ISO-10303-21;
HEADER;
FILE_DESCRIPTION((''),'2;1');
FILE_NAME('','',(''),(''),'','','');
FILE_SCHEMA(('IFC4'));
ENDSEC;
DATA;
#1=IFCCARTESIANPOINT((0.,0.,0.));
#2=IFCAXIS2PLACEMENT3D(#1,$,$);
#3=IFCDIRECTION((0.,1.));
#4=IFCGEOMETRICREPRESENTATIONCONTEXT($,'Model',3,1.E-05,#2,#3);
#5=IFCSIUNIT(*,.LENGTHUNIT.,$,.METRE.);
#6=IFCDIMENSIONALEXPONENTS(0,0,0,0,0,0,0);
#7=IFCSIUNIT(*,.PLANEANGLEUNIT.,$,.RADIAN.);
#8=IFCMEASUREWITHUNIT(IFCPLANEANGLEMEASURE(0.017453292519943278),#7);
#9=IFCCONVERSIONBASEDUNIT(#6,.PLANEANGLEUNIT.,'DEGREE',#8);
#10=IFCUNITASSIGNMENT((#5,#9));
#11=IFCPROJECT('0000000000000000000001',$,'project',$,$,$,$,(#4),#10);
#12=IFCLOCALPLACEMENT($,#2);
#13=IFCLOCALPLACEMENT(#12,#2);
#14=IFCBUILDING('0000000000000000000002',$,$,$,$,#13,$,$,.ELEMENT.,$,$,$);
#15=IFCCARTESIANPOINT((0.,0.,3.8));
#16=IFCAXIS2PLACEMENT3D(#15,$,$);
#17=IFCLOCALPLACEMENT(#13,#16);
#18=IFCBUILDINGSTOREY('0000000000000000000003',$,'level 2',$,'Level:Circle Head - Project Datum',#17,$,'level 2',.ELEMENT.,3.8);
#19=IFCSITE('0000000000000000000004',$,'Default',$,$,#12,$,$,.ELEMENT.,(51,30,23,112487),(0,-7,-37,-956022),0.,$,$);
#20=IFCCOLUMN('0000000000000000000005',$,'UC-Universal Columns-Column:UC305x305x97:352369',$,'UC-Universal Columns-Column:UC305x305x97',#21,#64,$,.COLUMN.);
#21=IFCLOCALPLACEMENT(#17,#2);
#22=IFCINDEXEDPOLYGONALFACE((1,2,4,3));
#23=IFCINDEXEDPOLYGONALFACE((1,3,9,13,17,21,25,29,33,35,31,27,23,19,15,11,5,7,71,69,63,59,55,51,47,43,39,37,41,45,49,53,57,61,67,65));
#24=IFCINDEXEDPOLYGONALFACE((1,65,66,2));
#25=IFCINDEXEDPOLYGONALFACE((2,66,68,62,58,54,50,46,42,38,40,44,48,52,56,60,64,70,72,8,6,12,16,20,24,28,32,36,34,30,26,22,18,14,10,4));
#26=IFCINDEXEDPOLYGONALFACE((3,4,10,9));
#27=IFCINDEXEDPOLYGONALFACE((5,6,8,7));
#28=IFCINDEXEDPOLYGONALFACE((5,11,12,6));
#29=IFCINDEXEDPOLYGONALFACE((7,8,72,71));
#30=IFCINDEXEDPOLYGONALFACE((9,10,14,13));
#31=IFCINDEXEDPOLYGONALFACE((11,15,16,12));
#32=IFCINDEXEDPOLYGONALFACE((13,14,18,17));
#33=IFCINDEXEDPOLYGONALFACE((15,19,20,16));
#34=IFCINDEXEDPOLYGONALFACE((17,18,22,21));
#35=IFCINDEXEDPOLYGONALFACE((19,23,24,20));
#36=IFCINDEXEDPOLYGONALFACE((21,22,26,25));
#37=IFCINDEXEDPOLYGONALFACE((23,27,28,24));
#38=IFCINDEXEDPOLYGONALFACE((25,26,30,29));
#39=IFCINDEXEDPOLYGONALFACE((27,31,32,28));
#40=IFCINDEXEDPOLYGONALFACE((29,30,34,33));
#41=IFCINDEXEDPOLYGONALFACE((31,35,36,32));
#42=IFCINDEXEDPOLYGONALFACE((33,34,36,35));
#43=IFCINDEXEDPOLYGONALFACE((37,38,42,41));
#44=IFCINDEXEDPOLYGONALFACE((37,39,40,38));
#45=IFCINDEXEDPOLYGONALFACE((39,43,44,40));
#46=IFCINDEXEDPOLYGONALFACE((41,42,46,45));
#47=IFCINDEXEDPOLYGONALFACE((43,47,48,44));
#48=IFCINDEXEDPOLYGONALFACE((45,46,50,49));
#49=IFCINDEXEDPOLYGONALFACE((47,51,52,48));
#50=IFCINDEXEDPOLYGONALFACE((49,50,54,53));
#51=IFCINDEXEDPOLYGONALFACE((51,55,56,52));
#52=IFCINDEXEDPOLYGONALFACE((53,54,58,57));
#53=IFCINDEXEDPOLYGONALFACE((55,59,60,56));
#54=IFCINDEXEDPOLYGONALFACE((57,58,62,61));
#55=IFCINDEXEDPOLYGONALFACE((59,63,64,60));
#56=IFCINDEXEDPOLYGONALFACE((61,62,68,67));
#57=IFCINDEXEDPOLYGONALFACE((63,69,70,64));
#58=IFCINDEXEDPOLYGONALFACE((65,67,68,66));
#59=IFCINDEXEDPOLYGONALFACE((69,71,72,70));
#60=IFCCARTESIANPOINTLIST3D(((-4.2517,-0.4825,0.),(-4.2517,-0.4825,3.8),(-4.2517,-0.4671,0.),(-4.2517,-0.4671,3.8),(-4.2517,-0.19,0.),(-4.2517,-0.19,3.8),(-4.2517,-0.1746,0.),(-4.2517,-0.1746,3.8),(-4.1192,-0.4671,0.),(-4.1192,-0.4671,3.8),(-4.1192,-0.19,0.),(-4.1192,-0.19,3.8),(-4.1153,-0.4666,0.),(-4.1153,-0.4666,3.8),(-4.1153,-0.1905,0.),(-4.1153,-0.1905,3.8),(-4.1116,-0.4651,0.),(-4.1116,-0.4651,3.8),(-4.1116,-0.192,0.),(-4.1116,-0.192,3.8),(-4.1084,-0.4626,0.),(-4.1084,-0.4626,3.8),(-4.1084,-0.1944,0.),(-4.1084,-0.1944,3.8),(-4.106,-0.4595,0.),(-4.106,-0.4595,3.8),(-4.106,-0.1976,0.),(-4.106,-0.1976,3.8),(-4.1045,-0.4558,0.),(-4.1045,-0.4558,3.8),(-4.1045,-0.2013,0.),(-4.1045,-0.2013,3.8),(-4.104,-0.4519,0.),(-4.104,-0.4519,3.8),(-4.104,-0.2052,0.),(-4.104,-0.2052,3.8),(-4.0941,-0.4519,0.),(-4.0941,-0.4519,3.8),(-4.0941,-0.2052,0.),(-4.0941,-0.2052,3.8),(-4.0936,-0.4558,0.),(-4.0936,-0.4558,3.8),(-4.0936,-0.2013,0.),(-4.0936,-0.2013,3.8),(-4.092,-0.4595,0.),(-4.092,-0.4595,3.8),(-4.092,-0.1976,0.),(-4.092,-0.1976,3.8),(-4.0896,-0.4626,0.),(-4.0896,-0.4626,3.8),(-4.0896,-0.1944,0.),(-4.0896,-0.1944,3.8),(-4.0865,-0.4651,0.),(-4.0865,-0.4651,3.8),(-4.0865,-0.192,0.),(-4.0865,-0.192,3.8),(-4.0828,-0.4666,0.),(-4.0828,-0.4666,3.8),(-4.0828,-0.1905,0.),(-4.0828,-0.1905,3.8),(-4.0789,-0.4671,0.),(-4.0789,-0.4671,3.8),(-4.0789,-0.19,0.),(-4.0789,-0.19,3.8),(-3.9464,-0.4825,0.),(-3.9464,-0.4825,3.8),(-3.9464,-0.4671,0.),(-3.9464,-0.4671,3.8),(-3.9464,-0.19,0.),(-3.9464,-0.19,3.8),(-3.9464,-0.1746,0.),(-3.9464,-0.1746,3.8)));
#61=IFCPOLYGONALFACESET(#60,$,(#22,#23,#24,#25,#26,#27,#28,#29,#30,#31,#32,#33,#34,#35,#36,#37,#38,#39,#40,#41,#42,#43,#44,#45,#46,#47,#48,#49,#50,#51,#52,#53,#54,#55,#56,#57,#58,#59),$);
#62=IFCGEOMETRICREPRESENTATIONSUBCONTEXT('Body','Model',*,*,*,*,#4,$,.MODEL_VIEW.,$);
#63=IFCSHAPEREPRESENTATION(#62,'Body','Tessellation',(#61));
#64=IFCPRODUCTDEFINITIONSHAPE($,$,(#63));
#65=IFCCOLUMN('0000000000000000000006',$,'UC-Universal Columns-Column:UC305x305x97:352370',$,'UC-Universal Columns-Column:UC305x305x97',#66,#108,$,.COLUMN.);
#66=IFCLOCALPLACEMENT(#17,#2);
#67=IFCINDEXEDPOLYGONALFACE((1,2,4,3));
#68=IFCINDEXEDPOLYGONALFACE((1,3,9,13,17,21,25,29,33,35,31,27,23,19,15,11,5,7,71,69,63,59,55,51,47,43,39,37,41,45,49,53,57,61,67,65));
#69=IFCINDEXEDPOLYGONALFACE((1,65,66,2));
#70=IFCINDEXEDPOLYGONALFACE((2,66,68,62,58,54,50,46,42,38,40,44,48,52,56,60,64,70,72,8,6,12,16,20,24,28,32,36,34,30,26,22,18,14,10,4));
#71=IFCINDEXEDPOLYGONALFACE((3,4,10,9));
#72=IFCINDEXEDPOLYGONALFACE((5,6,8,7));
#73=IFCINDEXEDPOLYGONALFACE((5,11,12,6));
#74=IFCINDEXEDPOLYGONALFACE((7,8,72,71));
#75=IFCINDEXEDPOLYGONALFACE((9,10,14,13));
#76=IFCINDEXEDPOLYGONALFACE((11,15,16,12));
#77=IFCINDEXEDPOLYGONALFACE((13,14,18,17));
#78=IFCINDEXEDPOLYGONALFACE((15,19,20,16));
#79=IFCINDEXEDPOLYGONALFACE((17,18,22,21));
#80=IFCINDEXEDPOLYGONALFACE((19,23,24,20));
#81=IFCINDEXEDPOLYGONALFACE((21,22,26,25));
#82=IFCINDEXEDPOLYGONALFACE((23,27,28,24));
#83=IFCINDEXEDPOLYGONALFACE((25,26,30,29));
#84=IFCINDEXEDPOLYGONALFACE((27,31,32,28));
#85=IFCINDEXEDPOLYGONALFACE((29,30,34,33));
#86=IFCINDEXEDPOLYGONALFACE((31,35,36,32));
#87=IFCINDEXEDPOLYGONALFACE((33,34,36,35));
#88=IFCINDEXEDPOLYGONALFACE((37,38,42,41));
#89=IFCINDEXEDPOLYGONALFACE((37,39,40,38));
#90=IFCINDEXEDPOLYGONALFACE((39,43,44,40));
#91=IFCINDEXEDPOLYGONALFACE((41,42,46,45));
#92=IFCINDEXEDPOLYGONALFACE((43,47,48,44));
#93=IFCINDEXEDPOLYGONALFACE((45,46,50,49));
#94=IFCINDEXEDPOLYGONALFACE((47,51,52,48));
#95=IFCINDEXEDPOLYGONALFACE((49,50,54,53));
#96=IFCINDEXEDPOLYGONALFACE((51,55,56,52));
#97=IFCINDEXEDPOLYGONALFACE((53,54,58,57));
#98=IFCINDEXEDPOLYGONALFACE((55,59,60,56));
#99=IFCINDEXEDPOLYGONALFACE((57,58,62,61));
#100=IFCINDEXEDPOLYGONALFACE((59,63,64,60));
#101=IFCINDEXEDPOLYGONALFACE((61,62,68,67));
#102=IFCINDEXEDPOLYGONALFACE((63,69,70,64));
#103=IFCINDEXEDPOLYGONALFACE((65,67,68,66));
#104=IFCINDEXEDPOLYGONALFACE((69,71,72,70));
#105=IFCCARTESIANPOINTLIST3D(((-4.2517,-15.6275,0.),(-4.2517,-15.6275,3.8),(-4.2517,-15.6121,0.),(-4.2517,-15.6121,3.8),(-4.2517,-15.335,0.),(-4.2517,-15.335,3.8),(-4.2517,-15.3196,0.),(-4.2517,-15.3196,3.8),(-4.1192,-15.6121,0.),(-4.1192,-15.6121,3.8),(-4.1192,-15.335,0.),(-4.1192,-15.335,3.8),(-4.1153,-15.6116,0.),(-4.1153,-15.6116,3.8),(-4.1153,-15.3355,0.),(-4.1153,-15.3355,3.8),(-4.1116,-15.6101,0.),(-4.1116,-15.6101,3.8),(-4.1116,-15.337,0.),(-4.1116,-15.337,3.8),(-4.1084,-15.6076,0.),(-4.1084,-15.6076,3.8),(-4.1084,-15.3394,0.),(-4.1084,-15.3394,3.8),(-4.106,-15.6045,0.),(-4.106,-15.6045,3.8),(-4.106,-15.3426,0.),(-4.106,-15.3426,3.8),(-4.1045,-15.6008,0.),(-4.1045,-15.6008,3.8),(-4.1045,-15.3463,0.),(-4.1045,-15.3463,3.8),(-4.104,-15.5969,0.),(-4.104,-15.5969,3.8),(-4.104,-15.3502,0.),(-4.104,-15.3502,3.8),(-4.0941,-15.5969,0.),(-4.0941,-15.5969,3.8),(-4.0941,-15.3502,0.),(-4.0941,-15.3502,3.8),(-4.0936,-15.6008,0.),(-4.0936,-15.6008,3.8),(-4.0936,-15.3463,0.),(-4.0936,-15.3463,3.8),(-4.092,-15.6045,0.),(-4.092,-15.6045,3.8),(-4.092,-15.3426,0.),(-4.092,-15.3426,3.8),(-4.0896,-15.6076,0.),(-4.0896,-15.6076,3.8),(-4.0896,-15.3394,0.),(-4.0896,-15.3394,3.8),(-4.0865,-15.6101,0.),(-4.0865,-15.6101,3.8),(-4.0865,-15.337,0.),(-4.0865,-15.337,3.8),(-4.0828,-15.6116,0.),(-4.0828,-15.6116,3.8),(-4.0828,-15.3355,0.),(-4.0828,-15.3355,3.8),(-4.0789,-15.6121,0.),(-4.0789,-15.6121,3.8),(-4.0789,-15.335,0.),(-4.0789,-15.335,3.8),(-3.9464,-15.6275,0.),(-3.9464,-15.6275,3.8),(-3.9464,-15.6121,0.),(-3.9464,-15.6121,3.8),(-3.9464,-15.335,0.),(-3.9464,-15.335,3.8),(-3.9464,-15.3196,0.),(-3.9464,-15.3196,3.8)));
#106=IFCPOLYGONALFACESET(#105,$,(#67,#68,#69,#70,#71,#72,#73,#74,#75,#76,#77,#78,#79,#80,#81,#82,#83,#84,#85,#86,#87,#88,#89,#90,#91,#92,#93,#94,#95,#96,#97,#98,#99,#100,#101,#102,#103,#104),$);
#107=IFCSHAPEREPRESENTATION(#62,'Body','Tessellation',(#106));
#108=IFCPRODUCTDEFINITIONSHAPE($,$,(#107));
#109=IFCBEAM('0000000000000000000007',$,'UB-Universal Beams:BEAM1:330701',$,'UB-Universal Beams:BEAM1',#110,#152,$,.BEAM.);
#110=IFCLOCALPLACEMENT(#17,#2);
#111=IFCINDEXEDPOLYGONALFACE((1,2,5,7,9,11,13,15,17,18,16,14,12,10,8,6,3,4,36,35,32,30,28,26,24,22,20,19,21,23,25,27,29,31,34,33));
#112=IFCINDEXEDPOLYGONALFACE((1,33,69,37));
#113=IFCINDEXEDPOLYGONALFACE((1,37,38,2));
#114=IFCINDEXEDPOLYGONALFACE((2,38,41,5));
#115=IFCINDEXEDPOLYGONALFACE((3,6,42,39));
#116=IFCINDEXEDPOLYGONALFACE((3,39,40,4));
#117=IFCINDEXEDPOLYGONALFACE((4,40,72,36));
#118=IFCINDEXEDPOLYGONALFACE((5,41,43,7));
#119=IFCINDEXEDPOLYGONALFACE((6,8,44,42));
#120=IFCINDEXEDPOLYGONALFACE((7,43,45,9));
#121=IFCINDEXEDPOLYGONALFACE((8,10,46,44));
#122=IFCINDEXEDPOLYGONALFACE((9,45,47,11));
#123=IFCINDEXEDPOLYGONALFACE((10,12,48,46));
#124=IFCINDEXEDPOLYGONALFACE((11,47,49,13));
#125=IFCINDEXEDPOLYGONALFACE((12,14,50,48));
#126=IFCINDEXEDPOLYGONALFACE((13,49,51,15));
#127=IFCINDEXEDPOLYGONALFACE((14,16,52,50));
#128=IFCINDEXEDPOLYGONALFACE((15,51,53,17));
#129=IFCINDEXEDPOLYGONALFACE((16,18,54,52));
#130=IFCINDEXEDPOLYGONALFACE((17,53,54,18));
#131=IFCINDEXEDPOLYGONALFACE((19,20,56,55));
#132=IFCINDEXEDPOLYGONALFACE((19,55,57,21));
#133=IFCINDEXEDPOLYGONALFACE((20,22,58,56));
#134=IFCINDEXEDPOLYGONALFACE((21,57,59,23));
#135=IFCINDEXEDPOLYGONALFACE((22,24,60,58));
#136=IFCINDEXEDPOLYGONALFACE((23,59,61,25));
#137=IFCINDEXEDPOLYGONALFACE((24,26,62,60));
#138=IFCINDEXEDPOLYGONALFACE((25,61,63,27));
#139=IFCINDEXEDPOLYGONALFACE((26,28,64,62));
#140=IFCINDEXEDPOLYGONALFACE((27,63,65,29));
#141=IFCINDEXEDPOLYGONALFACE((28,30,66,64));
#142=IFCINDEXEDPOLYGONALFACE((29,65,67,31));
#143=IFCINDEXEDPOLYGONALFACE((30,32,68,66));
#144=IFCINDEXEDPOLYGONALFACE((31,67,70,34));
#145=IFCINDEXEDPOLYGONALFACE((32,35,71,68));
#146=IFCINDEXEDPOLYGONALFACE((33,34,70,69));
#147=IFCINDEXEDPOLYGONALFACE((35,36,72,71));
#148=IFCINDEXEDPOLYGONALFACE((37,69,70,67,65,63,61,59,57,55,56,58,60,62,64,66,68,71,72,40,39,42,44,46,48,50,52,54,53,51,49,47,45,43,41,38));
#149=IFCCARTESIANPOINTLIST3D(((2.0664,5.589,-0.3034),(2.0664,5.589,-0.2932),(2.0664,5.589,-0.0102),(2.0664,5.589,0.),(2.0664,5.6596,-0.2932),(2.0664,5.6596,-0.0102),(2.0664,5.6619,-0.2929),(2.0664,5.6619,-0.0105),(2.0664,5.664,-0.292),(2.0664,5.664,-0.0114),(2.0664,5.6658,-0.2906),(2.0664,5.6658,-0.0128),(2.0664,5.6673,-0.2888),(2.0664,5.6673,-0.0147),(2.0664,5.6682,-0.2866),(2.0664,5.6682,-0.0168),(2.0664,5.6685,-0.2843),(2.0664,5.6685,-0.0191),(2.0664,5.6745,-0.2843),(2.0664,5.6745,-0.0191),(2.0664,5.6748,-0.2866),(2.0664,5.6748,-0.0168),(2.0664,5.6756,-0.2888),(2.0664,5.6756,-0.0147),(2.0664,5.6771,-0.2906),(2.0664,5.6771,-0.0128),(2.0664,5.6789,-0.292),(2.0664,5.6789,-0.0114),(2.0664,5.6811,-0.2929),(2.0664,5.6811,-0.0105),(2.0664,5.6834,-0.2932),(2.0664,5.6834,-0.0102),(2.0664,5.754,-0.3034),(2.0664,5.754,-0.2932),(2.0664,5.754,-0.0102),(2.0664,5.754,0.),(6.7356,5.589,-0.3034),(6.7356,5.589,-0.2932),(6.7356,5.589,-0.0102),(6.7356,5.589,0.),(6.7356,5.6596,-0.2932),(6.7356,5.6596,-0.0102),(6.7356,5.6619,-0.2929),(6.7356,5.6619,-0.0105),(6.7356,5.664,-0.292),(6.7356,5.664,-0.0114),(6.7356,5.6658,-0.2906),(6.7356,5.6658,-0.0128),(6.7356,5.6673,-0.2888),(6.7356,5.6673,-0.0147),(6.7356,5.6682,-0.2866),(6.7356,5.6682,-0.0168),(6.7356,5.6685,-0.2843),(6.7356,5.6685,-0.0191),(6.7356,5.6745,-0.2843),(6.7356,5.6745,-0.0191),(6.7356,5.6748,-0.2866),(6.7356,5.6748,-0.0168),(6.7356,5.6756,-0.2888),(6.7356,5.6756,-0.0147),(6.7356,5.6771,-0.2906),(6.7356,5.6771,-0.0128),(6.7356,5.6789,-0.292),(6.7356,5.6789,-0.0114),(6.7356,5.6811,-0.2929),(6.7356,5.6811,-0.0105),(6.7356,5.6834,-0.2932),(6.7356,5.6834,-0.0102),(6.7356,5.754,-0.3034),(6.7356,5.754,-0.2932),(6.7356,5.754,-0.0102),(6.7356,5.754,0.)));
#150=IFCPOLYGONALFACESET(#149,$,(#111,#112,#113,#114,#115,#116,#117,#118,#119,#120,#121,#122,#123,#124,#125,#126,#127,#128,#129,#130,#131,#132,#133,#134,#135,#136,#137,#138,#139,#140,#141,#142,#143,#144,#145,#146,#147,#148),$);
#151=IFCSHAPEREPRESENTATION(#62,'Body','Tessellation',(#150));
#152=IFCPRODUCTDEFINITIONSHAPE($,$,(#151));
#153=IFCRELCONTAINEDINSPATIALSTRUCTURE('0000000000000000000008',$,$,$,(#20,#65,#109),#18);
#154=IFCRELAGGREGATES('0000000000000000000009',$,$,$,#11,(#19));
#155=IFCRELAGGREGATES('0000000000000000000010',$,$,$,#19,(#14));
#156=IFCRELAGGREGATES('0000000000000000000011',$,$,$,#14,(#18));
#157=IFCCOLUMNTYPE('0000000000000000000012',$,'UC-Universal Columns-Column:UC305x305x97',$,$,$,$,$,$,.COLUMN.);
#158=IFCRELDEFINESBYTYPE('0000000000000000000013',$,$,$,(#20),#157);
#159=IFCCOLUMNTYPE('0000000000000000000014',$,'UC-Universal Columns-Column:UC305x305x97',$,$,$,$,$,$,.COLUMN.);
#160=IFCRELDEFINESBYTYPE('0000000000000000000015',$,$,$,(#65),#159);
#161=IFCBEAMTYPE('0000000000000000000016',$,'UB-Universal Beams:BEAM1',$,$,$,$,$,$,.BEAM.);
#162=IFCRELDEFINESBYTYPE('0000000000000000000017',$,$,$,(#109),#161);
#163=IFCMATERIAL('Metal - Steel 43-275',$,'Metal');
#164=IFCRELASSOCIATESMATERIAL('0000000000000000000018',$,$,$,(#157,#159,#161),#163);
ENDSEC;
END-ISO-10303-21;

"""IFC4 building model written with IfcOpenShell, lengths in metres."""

from ifc_helpers import new_model, entity, si_unit, converted_unit, direction, frame, frame_2d, origin, place, context, subcontext, project, spatial, polyline, circle_curve, parameter, trimmed, segment, composite_curve, i_section, outline, extrude, source, transform, mapped, material, material_profile, profile_set, type_object, type_shapes, element, save


model = new_model("IFC4")

# Units and contexts
model_context = context("Model", 3, precision=1e-05, world=origin(), true_north=direction((0.0, 1.0)))
body_context = subcontext(model_context, "Body", "Model", "MODEL_VIEW")
ifc_project = project(units=[si_unit("LENGTHUNIT", "METRE"), converted_unit("PLANEANGLEUNIT", "DEGREE", entity("IfcPlaneAngleMeasure", 0.017453292519943278), si_unit("PLANEANGLEUNIT", "RADIAN"), dimensions=[0, 0, 0, 0, 0, 0, 0])], contexts=[model_context])

# Site, building, storey
site_placement = place(None, origin())
site = spatial("IfcSite", under=ifc_project, at=site_placement, Name="Default", CompositionType="ELEMENT", RefLatitude=(51, 30, 23, 112487), RefLongitude=(0, -7, -37, -956022), RefElevation=0.0)
building_placement = place(site_placement, origin())
building = spatial("IfcBuilding", under=site, at=building_placement, CompositionType="ELEMENT")
storey_placement = place(building_placement, frame((0.0, 0.0, 3.8)))
storey = spatial("IfcBuildingStorey", under=building, at=storey_placement, Name="level 2", ObjectType="Level:Circle Head - Project Datum", LongName="level 2", CompositionType="ELEMENT", Elevation=3.8)

# Columns
ifc_material_1 = material(Name="Metal - Steel 43-275", Category="Metal")
ifc_material_profile_1 = material_profile(ifc_material_1, i_section(OverallWidth=0.3053, OverallDepth=0.3079, WebThickness=0.0099, FlangeThickness=0.0154, FilletRadius=0.0152, at=frame_2d((0.0, 0.0), x_axis=(1.0, 0.0))), Name="UC305x305x97")
ifc_profile_set_1 = profile_set([ifc_material_profile_1], Name="UC305x305x97")
column_type_1 = type_object("IfcColumnType", Name="UC-Universal Columns-Column:UC305x305x97", PredefinedType="COLUMN", material=ifc_profile_set_1)
shared_shape_1 = source(origin(), body_context, "Body", "SweptSolid", [
    extrude(i_section(OverallWidth=0.3053, OverallDepth=0.3079, WebThickness=0.0099, FlangeThickness=0.0154, FilletRadius=0.0152, at=frame_2d((0.0, 0.0), x_axis=(1.0, 0.0))), frame((-4.099, -0.3285, 3.8), z_axis=(0.0, 0.0, 1.0), x_axis=(-1.0, 0.0, 0.0)), (0.0, 0.0, 1.0), 3.8),
])
type_shapes(column_type_1, [shared_shape_1])
column_1_placement = place(storey_placement, frame((0.0, 0.0, -3.8)))
element("IfcColumn", 1, at=column_1_placement, inside=storey, type_object=column_type_1, Name="UC-Universal Columns-Column:UC305x305x97:352369", ObjectType="UC-Universal Columns-Column:UC305x305x97", PredefinedType="COLUMN", context=body_context, shape_type="MappedRepresentation", body=[
    mapped(shared_shape_1, transform((0.0, 0.0, 0.0), scale=1.0)),
])
column_type_2 = type_object("IfcColumnType", Name="UC-Universal Columns-Column:UC305x305x97", PredefinedType="COLUMN", material=ifc_profile_set_1)
shared_shape_2 = source(origin(), body_context, "Body", "SweptSolid", [
    extrude(i_section(OverallWidth=0.3053, OverallDepth=0.3079, WebThickness=0.0099, FlangeThickness=0.0154, FilletRadius=0.0152, at=frame_2d((0.0, 0.0), x_axis=(1.0, 0.0))), frame((-4.099, -15.4735, 3.8), z_axis=(0.0, 0.0, 1.0), x_axis=(-1.0, 0.0, 0.0)), (0.0, 0.0, 1.0), 3.8),
])
type_shapes(column_type_2, [shared_shape_2])
column_2_placement = place(storey_placement, frame((0.0, 0.0, -3.8)))
element("IfcColumn", 2, at=column_2_placement, inside=storey, type_object=column_type_2, Name="UC-Universal Columns-Column:UC305x305x97:352370", ObjectType="UC-Universal Columns-Column:UC305x305x97", PredefinedType="COLUMN", context=body_context, shape_type="MappedRepresentation", body=[
    mapped(shared_shape_2, transform((0.0, 0.0, 0.0), scale=1.0)),
])

# Beam
ifc_material_profile_2 = material_profile(ifc_material_1, outline(composite_curve([segment(polyline([(-0.0825, -0.1415), (-0.0825, -0.1517)]), True, "CONTINUOUS"), segment(polyline([(-0.0825, -0.1517), (0.0825, -0.1517)]), True, "CONTINUOUS"), segment(polyline([(0.0825, -0.1517), (0.0825, -0.1415)]), True, "CONTINUOUS"), segment(polyline([(0.0825, -0.1415), (0.0119, -0.1415)]), True, "CONTINUOUS"), segment(trimmed(circle_curve(frame_2d((0.0119, -0.1326), x_axis=(1.0, 0.0)), 0.0089), [parameter(180.0)], [parameter(270.0)], True, "PARAMETER"), False, "CONTINUOUS"), segment(polyline([(0.003, -0.1326), (0.003, 0.1326)]), True, "CONTINUOUS"), segment(trimmed(circle_curve(frame_2d((0.0119, 0.1326), x_axis=(1.0, 0.0)), 0.0089), [parameter(90.0)], [parameter(180.0)], True, "PARAMETER"), False, "CONTINUOUS"), segment(polyline([(0.0119, 0.1415), (0.0825, 0.1415)]), True, "CONTINUOUS"), segment(polyline([(0.0825, 0.1415), (0.0825, 0.1517)]), True, "CONTINUOUS"), segment(polyline([(0.0825, 0.1517), (-0.0825, 0.1517)]), True, "CONTINUOUS"), segment(polyline([(-0.0825, 0.1517), (-0.0825, 0.1415)]), True, "CONTINUOUS"), segment(polyline([(-0.0825, 0.1415), (-0.0119, 0.1415)]), True, "CONTINUOUS"), segment(trimmed(circle_curve(frame_2d((-0.0119, 0.1326), x_axis=(1.0, 0.0)), 0.0089), [parameter(360.0)], [parameter(90.0)], True, "PARAMETER"), False, "CONTINUOUS"), segment(polyline([(-0.003, 0.1326), (-0.003, -0.1326)]), True, "CONTINUOUS"), segment(trimmed(circle_curve(frame_2d((-0.0119, -0.1326), x_axis=(1.0, 0.0)), 0.0089), [parameter(270.0)], [parameter(360.0)], True, "PARAMETER"), False, "CONTINUOUS"), segment(polyline([(-0.0119, -0.1415), (-0.0825, -0.1415)]), True, "CONTINUOUS")], self_intersect=False)), Name="BEAM1")
ifc_profile_set_2 = profile_set([ifc_material_profile_2], Name="BEAM1")
beam_type_1 = type_object("IfcBeamType", Name="UB-Universal Beams:BEAM1", PredefinedType="BEAM", material=ifc_profile_set_2)
shared_shape_3 = source(origin(), body_context, "Body", "SweptSolid", [
    extrude(outline(composite_curve([segment(polyline([(-0.0825, -0.1415), (-0.0825, -0.1517)]), True, "CONTINUOUS"), segment(polyline([(-0.0825, -0.1517), (0.0825, -0.1517)]), True, "CONTINUOUS"), segment(polyline([(0.0825, -0.1517), (0.0825, -0.1415)]), True, "CONTINUOUS"), segment(polyline([(0.0825, -0.1415), (0.0119, -0.1415)]), True, "CONTINUOUS"), segment(trimmed(circle_curve(frame_2d((0.0119, -0.1326), x_axis=(1.0, 0.0)), 0.0089), [parameter(180.0)], [parameter(270.0)], True, "PARAMETER"), False, "CONTINUOUS"), segment(polyline([(0.003, -0.1326), (0.003, 0.1326)]), True, "CONTINUOUS"), segment(trimmed(circle_curve(frame_2d((0.0119, 0.1326), x_axis=(1.0, 0.0)), 0.0089), [parameter(90.0)], [parameter(180.0)], True, "PARAMETER"), False, "CONTINUOUS"), segment(polyline([(0.0119, 0.1415), (0.0825, 0.1415)]), True, "CONTINUOUS"), segment(polyline([(0.0825, 0.1415), (0.0825, 0.1517)]), True, "CONTINUOUS"), segment(polyline([(0.0825, 0.1517), (-0.0825, 0.1517)]), True, "CONTINUOUS"), segment(polyline([(-0.0825, 0.1517), (-0.0825, 0.1415)]), True, "CONTINUOUS"), segment(polyline([(-0.0825, 0.1415), (-0.0119, 0.1415)]), True, "CONTINUOUS"), segment(trimmed(circle_curve(frame_2d((-0.0119, 0.1326), x_axis=(1.0, 0.0)), 0.0089), [parameter(360.0)], [parameter(90.0)], True, "PARAMETER"), False, "CONTINUOUS"), segment(polyline([(-0.003, 0.1326), (-0.003, -0.1326)]), True, "CONTINUOUS"), segment(trimmed(circle_curve(frame_2d((-0.0119, -0.1326), x_axis=(1.0, 0.0)), 0.0089), [parameter(270.0)], [parameter(360.0)], True, "PARAMETER"), False, "CONTINUOUS"), segment(polyline([(-0.0119, -0.1415), (-0.0825, -0.1415)]), True, "CONTINUOUS")], self_intersect=False)), frame((-2.3346, 0.0, 0.0), z_axis=(-1.0, 0.0, 0.0), x_axis=(0.0, -1.0, 0.0)), (0.0, 0.0, -1.0), 4.6692),
])
type_shapes(beam_type_1, [shared_shape_3])
for number, where, name in (
    (3, (4.401, 5.6715, -0.1517), "UB-Universal Beams:BEAM1:330701"),
):
    element("IfcBeam", number, at=place(storey_placement, frame(where)), inside=storey, type_object=beam_type_1, Name=name, ObjectType="UB-Universal Beams:BEAM1", PredefinedType="BEAM", context=body_context, shape_type="MappedRepresentation", body=[
        mapped(shared_shape_3, transform((0.0, 0.0, 0.0), scale=1.0)),
    ])

save(model, "model.ifc")
